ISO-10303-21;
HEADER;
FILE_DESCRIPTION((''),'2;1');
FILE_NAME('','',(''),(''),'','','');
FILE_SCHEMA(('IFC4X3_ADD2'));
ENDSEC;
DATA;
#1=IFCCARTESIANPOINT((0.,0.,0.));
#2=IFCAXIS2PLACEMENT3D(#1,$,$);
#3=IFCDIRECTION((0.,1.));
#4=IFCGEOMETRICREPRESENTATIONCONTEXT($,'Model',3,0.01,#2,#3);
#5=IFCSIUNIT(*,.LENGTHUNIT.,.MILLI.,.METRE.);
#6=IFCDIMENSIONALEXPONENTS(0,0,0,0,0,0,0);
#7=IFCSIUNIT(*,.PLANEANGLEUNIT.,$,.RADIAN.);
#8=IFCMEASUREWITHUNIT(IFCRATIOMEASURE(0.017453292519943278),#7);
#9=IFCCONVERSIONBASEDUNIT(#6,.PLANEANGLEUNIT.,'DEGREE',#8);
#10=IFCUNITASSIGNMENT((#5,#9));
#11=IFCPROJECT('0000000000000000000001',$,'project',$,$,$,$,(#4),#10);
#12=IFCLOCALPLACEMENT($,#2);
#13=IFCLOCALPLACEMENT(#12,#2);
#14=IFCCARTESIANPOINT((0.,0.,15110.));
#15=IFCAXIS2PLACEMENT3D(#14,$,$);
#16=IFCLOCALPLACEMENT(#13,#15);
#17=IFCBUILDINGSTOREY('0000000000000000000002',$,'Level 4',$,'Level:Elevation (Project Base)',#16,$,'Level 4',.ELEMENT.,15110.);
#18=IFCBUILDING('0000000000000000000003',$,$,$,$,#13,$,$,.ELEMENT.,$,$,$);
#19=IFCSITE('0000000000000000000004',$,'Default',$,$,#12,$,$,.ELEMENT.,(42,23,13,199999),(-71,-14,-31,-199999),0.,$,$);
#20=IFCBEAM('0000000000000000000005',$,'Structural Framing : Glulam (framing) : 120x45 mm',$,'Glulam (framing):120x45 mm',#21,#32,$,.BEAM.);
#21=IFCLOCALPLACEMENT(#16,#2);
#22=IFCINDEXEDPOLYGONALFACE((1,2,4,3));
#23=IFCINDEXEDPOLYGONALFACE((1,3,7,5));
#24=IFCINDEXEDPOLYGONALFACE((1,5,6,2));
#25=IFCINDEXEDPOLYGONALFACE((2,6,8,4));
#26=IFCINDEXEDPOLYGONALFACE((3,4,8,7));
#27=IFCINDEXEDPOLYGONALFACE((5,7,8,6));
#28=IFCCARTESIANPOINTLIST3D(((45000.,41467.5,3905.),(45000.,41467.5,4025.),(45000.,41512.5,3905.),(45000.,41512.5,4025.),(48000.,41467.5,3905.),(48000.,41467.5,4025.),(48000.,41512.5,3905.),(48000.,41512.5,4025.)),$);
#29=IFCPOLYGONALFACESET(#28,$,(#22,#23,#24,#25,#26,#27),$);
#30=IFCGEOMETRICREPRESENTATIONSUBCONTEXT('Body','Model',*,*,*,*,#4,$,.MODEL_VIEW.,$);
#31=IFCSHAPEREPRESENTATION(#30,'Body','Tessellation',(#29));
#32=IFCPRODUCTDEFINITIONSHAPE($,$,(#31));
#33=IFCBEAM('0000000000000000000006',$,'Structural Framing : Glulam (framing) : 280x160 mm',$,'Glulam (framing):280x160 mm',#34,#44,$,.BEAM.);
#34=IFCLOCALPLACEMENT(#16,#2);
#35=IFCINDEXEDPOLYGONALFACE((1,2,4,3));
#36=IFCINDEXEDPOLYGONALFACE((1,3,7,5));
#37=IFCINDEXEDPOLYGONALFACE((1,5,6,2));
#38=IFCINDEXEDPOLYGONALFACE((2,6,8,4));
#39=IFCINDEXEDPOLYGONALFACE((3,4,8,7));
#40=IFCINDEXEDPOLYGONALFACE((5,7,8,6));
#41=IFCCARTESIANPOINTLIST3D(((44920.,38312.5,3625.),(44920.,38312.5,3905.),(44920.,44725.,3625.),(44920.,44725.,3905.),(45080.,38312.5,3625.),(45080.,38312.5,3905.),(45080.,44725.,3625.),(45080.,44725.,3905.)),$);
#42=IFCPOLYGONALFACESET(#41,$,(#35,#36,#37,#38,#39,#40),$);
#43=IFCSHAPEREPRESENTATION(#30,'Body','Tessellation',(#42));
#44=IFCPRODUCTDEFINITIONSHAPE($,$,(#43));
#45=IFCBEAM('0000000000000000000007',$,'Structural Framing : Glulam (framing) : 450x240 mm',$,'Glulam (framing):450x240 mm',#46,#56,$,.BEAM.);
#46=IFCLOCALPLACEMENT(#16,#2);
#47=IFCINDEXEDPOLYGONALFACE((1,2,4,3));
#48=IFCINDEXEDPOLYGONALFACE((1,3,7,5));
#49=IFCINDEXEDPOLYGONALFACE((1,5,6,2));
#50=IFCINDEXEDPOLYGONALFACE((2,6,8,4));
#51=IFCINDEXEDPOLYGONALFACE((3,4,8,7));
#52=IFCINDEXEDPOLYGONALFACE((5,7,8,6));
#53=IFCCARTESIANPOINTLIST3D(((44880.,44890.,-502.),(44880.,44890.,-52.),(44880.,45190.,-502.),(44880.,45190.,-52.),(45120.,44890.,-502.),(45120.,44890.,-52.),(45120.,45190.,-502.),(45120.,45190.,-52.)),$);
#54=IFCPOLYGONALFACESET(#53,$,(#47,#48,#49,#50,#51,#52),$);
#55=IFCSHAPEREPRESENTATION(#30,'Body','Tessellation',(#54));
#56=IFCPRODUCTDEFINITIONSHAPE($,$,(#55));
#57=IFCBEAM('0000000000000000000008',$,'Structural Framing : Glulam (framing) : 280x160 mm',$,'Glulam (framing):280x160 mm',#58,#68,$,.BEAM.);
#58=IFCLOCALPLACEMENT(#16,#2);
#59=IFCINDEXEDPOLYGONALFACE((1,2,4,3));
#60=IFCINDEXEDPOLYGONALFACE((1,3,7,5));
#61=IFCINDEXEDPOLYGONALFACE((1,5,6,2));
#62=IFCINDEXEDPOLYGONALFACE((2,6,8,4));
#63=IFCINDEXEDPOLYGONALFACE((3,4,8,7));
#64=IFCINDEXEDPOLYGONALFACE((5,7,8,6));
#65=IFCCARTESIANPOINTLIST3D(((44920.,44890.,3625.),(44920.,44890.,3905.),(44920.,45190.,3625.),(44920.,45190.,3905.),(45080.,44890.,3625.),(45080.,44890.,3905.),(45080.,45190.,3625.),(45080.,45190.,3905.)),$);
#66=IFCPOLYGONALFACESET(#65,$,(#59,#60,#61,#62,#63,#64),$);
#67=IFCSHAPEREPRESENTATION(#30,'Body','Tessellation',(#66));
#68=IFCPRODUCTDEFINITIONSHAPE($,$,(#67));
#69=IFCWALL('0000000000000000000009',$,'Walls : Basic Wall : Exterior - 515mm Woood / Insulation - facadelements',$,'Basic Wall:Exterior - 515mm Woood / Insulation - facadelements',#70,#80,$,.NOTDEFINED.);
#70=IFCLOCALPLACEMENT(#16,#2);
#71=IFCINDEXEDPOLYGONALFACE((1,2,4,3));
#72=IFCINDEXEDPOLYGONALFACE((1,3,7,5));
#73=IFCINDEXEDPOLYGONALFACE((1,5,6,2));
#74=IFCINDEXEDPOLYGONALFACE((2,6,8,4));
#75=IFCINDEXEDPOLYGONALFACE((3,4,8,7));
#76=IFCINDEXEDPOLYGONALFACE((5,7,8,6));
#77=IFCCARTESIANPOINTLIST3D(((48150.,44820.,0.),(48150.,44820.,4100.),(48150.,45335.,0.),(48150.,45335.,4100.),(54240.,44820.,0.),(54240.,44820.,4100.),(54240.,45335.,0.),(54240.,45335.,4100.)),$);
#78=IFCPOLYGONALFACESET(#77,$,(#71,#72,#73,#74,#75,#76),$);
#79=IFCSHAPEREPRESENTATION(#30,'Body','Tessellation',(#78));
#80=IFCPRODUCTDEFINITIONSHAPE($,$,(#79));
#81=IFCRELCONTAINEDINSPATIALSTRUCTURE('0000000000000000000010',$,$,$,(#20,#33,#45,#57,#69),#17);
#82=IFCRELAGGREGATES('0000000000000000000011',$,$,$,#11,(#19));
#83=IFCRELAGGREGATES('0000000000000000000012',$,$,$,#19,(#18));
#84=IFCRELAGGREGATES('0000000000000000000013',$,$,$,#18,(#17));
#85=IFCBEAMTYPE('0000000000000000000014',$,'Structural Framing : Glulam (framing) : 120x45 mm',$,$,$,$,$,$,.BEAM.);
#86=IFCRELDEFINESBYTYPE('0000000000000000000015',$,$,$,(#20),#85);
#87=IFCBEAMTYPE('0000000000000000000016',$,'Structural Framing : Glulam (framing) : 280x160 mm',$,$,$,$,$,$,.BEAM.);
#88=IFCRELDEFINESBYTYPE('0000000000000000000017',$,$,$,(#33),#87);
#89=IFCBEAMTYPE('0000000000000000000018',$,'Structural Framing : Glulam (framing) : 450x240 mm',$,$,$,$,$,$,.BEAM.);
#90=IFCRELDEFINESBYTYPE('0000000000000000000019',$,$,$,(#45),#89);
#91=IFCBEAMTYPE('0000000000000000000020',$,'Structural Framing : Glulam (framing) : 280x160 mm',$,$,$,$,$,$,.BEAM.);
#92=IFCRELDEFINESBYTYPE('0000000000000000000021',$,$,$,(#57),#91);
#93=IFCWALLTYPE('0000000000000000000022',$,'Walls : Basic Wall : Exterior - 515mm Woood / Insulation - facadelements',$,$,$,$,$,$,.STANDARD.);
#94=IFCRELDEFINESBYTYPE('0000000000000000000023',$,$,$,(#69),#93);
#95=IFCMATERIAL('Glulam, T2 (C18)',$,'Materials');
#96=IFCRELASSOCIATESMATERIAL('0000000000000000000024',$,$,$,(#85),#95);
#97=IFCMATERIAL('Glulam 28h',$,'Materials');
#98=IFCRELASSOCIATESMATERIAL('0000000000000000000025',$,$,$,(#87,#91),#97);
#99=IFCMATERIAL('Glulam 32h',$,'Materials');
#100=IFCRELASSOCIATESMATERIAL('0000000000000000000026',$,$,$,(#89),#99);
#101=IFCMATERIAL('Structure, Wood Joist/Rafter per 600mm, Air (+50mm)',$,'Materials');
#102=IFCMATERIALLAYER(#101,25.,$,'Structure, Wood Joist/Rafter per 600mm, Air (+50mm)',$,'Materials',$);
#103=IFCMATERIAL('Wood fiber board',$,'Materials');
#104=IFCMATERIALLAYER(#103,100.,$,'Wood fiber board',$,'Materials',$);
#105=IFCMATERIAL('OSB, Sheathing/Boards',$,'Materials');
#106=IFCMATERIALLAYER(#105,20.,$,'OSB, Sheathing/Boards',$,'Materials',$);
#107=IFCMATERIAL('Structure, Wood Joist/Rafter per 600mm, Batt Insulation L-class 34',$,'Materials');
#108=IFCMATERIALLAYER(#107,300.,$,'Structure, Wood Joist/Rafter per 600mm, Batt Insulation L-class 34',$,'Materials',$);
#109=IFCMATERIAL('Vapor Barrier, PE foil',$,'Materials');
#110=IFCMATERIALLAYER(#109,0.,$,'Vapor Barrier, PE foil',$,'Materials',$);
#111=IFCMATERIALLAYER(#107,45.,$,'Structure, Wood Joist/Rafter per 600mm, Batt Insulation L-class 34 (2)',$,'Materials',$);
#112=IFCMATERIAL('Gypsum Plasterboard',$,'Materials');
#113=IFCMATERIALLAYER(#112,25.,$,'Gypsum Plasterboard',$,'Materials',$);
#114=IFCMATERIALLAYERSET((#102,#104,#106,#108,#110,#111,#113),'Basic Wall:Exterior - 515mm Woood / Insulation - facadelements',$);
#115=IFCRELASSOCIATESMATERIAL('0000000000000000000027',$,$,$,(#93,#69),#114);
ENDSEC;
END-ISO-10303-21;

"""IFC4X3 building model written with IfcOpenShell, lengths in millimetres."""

from ifc_helpers import new_model, entity, si_unit, converted_unit, direction, frame, frame_2d, origin, origin_2d_with_axis, place, context, subcontext, project, spatial, rectangle, extrude, source, transform, mapped, material, layer, layer_set, material_profile, profile_set, type_object, type_shapes, element, save


model = new_model("IFC4X3")

# Units and contexts
model_context = context("Model", 3, precision=0.01, world=origin(), true_north=direction((0.0, 1.0)))
body_context = subcontext(model_context, "Body", "Model", "MODEL_VIEW")
ifc_project = project(units=[si_unit("LENGTHUNIT", "METRE", prefix="MILLI"), converted_unit("PLANEANGLEUNIT", "DEGREE", entity("IfcRatioMeasure", 0.017453292519943278), si_unit("PLANEANGLEUNIT", "RADIAN"), dimensions=[0, 0, 0, 0, 0, 0, 0])], contexts=[model_context])

# Site, building, storey
site_placement = place(None, origin())
site = spatial("IfcSite", under=ifc_project, at=site_placement, Name="Default", CompositionType="ELEMENT", RefLatitude=(42, 23, 13, 199999), RefLongitude=(-71, -14, -31, -199999), RefElevation=0.0)
building_placement = place(site_placement, origin())
building = spatial("IfcBuilding", under=site, at=building_placement, CompositionType="ELEMENT")
storey_placement = place(building_placement, frame((0.0, 0.0, 15110.0)))
storey = spatial("IfcBuildingStorey", under=building, at=storey_placement, Name="Level 4", ObjectType="Level:Elevation (Project Base)", LongName="Level 4", CompositionType="ELEMENT", Elevation=15110.0)

# Beams
ifc_material_1 = material(Name="Glulam 32h", Category="Materials")
ifc_material_profile_1 = material_profile(ifc_material_1, rectangle(XDim=450.0, YDim=240.0, at=origin_2d_with_axis()), Name="450x240 mm")
ifc_profile_set_1 = profile_set([ifc_material_profile_1], Name="450x240 mm")
ifc_material_2 = material(Name="Glulam, T2 (C18)", Category="Materials")
ifc_material_profile_2 = material_profile(ifc_material_2, rectangle(XDim=120.0, YDim=45.0, at=origin_2d_with_axis()), Name="120x45 mm")
ifc_profile_set_2 = profile_set([ifc_material_profile_2], Name="120x45 mm")
beam_type_1 = type_object("IfcBeamType", Name="Structural Framing : Glulam (framing) : 120x45 mm", PredefinedType="BEAM", material=ifc_profile_set_2)
shared_shape_1 = source(origin(), body_context, "Body", "SweptSolid", [
    extrude(rectangle(XDim=120.0, YDim=45.0, at=origin_2d_with_axis()), frame((500.0, 0.0, 0.0), z_axis=(1.0, 0.0, 0.0), x_axis=(0.0, 0.0, -1.0)), (0.0, 0.0, 1.0), 3000.0),
])
type_shapes(beam_type_1, [shared_shape_1])
for number, where, name in (
    (1, (44500.0, 41490.0, 3965.0), "Structural Framing : Glulam (framing) : 120x45 mm"),
):
    element("IfcBeam", number, at=place(storey_placement, frame(where)), inside=storey, type_object=beam_type_1, Name=name, ObjectType="Glulam (framing):120x45 mm", PredefinedType="BEAM", context=body_context, shape_type="MappedRepresentation", body=[
        mapped(shared_shape_1, transform((0.0, 0.0, 0.0), scale=1.0)),
    ])
ifc_material_3 = material(Name="Glulam 28h", Category="Materials")
ifc_material_profile_3 = material_profile(ifc_material_3, rectangle(XDim=280.0, YDim=160.0, at=origin_2d_with_axis()), Name="280x160 mm")
ifc_profile_set_3 = profile_set([ifc_material_profile_3], Name="280x160 mm")
beam_type_2 = type_object("IfcBeamType", Name="Structural Framing : Glulam (framing) : 280x160 mm", PredefinedType="BEAM", material=ifc_profile_set_3)
shared_shape_2 = source(origin(), body_context, "Body", "SweptSolid", [
    extrude(rectangle(XDim=280.0, YDim=160.0, at=origin_2d_with_axis()), frame((-2932.5, 0.0, 0.0), z_axis=(1.0, 0.0, 0.0), x_axis=(0.0, 0.0, -1.0)), (0.0, 0.0, 1.0), 6412.5),
])
type_shapes(beam_type_2, [shared_shape_2])
beam_1_placement = place(storey_placement, frame((45000.0, 41792.5, 3765.0), z_axis=(0.0, 0.0, 1.0), x_axis=(0.0, -1.0, 0.0)))
element("IfcBeam", 2, at=beam_1_placement, inside=storey, type_object=beam_type_2, Name="Structural Framing : Glulam (framing) : 280x160 mm", ObjectType="Glulam (framing):280x160 mm", PredefinedType="BEAM", context=body_context, shape_type="MappedRepresentation", body=[
    mapped(shared_shape_2, transform((0.0, 0.0, 0.0), scale=1.0)),
])
beam_type_3 = type_object("IfcBeamType", Name="Structural Framing : Glulam (framing) : 450x240 mm", PredefinedType="BEAM", material=ifc_profile_set_1)
shared_shape_3 = source(origin(), body_context, "Body", "SweptSolid", [
    extrude(rectangle(XDim=450.0, YDim=240.0, at=origin_2d_with_axis()), frame((-1110.0, 0.0, 0.0), z_axis=(1.0, 0.0, 0.0), x_axis=(0.0, 0.0, -1.0)), (0.0, 0.0, 1.0), 300.0),
])
type_shapes(beam_type_3, [shared_shape_3])
beam_2_placement = place(storey_placement, frame((45000.0, 44080.0, -277.0), z_axis=(0.0, 0.0, 1.0), x_axis=(0.0, -1.0, 0.0)))
element("IfcBeam", 3, at=beam_2_placement, inside=storey, type_object=beam_type_3, Name="Structural Framing : Glulam (framing) : 450x240 mm", ObjectType="Glulam (framing):450x240 mm", PredefinedType="BEAM", context=body_context, shape_type="MappedRepresentation", body=[
    mapped(shared_shape_3, transform((0.0, 0.0, 0.0), scale=1.0)),
])
beam_type_4 = type_object("IfcBeamType", Name="Structural Framing : Glulam (framing) : 280x160 mm", PredefinedType="BEAM", material=ifc_profile_set_3)
shared_shape_4 = source(origin(), body_context, "Body", "SweptSolid", [
    extrude(rectangle(XDim=280.0, YDim=160.0, at=origin_2d_with_axis()), frame((5322.5, 0.0, 0.0), z_axis=(1.0, 0.0, 0.0), x_axis=(0.0, 0.0, -1.0)), (0.0, 0.0, 1.0), 300.0),
])
type_shapes(beam_type_4, [shared_shape_4])
beam_3_placement = place(storey_placement, frame((45000.0, 50512.5, 3765.0), z_axis=(0.0, 0.0, 1.0), x_axis=(0.0, -1.0, 0.0)))
element("IfcBeam", 4, at=beam_3_placement, inside=storey, type_object=beam_type_4, Name="Structural Framing : Glulam (framing) : 280x160 mm", ObjectType="Glulam (framing):280x160 mm", PredefinedType="BEAM", context=body_context, shape_type="MappedRepresentation", body=[
    mapped(shared_shape_4, transform((0.0, 0.0, 0.0), scale=1.0)),
])

# Wall
ifc_material_4 = material(Name="Structure, Wood Joist/Rafter per 600mm, Air (+50mm)", Category="Materials")
ifc_layer_1 = layer(ifc_material_4, 25.0, Name="Structure, Wood Joist/Rafter per 600mm, Air (+50mm)", Category="Materials")
ifc_material_5 = material(Name="Wood fiber board", Category="Materials")
ifc_layer_2 = layer(ifc_material_5, 100.0, Name="Wood fiber board", Category="Materials")
ifc_material_6 = material(Name="OSB, Sheathing/Boards", Category="Materials")
ifc_layer_3 = layer(ifc_material_6, 20.0, Name="OSB, Sheathing/Boards", Category="Materials")
ifc_material_7 = material(Name="Structure, Wood Joist/Rafter per 600mm, Batt Insulation L-class 34", Category="Materials")
ifc_layer_4 = layer(ifc_material_7, 300.0, Name="Structure, Wood Joist/Rafter per 600mm, Batt Insulation L-class 34", Category="Materials")
ifc_material_8 = material(Name="Vapor Barrier, PE foil", Category="Materials")
ifc_layer_5 = layer(ifc_material_8, 0.0, Name="Vapor Barrier, PE foil", Category="Materials")
ifc_layer_6 = layer(ifc_material_7, 45.0, Name="Structure, Wood Joist/Rafter per 600mm, Batt Insulation L-class 34 (2)", Category="Materials")
ifc_material_9 = material(Name="Gypsum Plasterboard", Category="Materials")
ifc_layer_7 = layer(ifc_material_9, 25.0, Name="Gypsum Plasterboard", Category="Materials")
ifc_layer_set = layer_set([ifc_layer_1, ifc_layer_2, ifc_layer_3, ifc_layer_4, ifc_layer_5, ifc_layer_6, ifc_layer_7], Name="Basic Wall:Exterior - 515mm Woood / Insulation - facadelements")
wall_type = type_object("IfcWallType", Name="Walls : Basic Wall : Exterior - 515mm Woood / Insulation - facadelements", PredefinedType="STANDARD", material=ifc_layer_set)
wall_placement = place(storey_placement, frame((54240.0, 45077.5, 0.0), z_axis=(0.0, 0.0, 1.0), x_axis=(-1.0, 0.0, 0.0)))
element("IfcWall", 5, at=wall_placement, inside=storey, type_object=wall_type, material=ifc_layer_set, Name="Walls : Basic Wall : Exterior - 515mm Woood / Insulation - facadelements", ObjectType="Basic Wall:Exterior - 515mm Woood / Insulation - facadelements", PredefinedType="NOTDEFINED", context=body_context, shape_type="SweptSolid", body=[
    extrude(rectangle(XDim=6090.0, YDim=515.0, at=frame_2d((3045.0, 0.0), x_axis=(-1.0, 0.0))), origin(), (0.0, 0.0, 1.0), 4100.0),
])

save(model, "model.ifc")
